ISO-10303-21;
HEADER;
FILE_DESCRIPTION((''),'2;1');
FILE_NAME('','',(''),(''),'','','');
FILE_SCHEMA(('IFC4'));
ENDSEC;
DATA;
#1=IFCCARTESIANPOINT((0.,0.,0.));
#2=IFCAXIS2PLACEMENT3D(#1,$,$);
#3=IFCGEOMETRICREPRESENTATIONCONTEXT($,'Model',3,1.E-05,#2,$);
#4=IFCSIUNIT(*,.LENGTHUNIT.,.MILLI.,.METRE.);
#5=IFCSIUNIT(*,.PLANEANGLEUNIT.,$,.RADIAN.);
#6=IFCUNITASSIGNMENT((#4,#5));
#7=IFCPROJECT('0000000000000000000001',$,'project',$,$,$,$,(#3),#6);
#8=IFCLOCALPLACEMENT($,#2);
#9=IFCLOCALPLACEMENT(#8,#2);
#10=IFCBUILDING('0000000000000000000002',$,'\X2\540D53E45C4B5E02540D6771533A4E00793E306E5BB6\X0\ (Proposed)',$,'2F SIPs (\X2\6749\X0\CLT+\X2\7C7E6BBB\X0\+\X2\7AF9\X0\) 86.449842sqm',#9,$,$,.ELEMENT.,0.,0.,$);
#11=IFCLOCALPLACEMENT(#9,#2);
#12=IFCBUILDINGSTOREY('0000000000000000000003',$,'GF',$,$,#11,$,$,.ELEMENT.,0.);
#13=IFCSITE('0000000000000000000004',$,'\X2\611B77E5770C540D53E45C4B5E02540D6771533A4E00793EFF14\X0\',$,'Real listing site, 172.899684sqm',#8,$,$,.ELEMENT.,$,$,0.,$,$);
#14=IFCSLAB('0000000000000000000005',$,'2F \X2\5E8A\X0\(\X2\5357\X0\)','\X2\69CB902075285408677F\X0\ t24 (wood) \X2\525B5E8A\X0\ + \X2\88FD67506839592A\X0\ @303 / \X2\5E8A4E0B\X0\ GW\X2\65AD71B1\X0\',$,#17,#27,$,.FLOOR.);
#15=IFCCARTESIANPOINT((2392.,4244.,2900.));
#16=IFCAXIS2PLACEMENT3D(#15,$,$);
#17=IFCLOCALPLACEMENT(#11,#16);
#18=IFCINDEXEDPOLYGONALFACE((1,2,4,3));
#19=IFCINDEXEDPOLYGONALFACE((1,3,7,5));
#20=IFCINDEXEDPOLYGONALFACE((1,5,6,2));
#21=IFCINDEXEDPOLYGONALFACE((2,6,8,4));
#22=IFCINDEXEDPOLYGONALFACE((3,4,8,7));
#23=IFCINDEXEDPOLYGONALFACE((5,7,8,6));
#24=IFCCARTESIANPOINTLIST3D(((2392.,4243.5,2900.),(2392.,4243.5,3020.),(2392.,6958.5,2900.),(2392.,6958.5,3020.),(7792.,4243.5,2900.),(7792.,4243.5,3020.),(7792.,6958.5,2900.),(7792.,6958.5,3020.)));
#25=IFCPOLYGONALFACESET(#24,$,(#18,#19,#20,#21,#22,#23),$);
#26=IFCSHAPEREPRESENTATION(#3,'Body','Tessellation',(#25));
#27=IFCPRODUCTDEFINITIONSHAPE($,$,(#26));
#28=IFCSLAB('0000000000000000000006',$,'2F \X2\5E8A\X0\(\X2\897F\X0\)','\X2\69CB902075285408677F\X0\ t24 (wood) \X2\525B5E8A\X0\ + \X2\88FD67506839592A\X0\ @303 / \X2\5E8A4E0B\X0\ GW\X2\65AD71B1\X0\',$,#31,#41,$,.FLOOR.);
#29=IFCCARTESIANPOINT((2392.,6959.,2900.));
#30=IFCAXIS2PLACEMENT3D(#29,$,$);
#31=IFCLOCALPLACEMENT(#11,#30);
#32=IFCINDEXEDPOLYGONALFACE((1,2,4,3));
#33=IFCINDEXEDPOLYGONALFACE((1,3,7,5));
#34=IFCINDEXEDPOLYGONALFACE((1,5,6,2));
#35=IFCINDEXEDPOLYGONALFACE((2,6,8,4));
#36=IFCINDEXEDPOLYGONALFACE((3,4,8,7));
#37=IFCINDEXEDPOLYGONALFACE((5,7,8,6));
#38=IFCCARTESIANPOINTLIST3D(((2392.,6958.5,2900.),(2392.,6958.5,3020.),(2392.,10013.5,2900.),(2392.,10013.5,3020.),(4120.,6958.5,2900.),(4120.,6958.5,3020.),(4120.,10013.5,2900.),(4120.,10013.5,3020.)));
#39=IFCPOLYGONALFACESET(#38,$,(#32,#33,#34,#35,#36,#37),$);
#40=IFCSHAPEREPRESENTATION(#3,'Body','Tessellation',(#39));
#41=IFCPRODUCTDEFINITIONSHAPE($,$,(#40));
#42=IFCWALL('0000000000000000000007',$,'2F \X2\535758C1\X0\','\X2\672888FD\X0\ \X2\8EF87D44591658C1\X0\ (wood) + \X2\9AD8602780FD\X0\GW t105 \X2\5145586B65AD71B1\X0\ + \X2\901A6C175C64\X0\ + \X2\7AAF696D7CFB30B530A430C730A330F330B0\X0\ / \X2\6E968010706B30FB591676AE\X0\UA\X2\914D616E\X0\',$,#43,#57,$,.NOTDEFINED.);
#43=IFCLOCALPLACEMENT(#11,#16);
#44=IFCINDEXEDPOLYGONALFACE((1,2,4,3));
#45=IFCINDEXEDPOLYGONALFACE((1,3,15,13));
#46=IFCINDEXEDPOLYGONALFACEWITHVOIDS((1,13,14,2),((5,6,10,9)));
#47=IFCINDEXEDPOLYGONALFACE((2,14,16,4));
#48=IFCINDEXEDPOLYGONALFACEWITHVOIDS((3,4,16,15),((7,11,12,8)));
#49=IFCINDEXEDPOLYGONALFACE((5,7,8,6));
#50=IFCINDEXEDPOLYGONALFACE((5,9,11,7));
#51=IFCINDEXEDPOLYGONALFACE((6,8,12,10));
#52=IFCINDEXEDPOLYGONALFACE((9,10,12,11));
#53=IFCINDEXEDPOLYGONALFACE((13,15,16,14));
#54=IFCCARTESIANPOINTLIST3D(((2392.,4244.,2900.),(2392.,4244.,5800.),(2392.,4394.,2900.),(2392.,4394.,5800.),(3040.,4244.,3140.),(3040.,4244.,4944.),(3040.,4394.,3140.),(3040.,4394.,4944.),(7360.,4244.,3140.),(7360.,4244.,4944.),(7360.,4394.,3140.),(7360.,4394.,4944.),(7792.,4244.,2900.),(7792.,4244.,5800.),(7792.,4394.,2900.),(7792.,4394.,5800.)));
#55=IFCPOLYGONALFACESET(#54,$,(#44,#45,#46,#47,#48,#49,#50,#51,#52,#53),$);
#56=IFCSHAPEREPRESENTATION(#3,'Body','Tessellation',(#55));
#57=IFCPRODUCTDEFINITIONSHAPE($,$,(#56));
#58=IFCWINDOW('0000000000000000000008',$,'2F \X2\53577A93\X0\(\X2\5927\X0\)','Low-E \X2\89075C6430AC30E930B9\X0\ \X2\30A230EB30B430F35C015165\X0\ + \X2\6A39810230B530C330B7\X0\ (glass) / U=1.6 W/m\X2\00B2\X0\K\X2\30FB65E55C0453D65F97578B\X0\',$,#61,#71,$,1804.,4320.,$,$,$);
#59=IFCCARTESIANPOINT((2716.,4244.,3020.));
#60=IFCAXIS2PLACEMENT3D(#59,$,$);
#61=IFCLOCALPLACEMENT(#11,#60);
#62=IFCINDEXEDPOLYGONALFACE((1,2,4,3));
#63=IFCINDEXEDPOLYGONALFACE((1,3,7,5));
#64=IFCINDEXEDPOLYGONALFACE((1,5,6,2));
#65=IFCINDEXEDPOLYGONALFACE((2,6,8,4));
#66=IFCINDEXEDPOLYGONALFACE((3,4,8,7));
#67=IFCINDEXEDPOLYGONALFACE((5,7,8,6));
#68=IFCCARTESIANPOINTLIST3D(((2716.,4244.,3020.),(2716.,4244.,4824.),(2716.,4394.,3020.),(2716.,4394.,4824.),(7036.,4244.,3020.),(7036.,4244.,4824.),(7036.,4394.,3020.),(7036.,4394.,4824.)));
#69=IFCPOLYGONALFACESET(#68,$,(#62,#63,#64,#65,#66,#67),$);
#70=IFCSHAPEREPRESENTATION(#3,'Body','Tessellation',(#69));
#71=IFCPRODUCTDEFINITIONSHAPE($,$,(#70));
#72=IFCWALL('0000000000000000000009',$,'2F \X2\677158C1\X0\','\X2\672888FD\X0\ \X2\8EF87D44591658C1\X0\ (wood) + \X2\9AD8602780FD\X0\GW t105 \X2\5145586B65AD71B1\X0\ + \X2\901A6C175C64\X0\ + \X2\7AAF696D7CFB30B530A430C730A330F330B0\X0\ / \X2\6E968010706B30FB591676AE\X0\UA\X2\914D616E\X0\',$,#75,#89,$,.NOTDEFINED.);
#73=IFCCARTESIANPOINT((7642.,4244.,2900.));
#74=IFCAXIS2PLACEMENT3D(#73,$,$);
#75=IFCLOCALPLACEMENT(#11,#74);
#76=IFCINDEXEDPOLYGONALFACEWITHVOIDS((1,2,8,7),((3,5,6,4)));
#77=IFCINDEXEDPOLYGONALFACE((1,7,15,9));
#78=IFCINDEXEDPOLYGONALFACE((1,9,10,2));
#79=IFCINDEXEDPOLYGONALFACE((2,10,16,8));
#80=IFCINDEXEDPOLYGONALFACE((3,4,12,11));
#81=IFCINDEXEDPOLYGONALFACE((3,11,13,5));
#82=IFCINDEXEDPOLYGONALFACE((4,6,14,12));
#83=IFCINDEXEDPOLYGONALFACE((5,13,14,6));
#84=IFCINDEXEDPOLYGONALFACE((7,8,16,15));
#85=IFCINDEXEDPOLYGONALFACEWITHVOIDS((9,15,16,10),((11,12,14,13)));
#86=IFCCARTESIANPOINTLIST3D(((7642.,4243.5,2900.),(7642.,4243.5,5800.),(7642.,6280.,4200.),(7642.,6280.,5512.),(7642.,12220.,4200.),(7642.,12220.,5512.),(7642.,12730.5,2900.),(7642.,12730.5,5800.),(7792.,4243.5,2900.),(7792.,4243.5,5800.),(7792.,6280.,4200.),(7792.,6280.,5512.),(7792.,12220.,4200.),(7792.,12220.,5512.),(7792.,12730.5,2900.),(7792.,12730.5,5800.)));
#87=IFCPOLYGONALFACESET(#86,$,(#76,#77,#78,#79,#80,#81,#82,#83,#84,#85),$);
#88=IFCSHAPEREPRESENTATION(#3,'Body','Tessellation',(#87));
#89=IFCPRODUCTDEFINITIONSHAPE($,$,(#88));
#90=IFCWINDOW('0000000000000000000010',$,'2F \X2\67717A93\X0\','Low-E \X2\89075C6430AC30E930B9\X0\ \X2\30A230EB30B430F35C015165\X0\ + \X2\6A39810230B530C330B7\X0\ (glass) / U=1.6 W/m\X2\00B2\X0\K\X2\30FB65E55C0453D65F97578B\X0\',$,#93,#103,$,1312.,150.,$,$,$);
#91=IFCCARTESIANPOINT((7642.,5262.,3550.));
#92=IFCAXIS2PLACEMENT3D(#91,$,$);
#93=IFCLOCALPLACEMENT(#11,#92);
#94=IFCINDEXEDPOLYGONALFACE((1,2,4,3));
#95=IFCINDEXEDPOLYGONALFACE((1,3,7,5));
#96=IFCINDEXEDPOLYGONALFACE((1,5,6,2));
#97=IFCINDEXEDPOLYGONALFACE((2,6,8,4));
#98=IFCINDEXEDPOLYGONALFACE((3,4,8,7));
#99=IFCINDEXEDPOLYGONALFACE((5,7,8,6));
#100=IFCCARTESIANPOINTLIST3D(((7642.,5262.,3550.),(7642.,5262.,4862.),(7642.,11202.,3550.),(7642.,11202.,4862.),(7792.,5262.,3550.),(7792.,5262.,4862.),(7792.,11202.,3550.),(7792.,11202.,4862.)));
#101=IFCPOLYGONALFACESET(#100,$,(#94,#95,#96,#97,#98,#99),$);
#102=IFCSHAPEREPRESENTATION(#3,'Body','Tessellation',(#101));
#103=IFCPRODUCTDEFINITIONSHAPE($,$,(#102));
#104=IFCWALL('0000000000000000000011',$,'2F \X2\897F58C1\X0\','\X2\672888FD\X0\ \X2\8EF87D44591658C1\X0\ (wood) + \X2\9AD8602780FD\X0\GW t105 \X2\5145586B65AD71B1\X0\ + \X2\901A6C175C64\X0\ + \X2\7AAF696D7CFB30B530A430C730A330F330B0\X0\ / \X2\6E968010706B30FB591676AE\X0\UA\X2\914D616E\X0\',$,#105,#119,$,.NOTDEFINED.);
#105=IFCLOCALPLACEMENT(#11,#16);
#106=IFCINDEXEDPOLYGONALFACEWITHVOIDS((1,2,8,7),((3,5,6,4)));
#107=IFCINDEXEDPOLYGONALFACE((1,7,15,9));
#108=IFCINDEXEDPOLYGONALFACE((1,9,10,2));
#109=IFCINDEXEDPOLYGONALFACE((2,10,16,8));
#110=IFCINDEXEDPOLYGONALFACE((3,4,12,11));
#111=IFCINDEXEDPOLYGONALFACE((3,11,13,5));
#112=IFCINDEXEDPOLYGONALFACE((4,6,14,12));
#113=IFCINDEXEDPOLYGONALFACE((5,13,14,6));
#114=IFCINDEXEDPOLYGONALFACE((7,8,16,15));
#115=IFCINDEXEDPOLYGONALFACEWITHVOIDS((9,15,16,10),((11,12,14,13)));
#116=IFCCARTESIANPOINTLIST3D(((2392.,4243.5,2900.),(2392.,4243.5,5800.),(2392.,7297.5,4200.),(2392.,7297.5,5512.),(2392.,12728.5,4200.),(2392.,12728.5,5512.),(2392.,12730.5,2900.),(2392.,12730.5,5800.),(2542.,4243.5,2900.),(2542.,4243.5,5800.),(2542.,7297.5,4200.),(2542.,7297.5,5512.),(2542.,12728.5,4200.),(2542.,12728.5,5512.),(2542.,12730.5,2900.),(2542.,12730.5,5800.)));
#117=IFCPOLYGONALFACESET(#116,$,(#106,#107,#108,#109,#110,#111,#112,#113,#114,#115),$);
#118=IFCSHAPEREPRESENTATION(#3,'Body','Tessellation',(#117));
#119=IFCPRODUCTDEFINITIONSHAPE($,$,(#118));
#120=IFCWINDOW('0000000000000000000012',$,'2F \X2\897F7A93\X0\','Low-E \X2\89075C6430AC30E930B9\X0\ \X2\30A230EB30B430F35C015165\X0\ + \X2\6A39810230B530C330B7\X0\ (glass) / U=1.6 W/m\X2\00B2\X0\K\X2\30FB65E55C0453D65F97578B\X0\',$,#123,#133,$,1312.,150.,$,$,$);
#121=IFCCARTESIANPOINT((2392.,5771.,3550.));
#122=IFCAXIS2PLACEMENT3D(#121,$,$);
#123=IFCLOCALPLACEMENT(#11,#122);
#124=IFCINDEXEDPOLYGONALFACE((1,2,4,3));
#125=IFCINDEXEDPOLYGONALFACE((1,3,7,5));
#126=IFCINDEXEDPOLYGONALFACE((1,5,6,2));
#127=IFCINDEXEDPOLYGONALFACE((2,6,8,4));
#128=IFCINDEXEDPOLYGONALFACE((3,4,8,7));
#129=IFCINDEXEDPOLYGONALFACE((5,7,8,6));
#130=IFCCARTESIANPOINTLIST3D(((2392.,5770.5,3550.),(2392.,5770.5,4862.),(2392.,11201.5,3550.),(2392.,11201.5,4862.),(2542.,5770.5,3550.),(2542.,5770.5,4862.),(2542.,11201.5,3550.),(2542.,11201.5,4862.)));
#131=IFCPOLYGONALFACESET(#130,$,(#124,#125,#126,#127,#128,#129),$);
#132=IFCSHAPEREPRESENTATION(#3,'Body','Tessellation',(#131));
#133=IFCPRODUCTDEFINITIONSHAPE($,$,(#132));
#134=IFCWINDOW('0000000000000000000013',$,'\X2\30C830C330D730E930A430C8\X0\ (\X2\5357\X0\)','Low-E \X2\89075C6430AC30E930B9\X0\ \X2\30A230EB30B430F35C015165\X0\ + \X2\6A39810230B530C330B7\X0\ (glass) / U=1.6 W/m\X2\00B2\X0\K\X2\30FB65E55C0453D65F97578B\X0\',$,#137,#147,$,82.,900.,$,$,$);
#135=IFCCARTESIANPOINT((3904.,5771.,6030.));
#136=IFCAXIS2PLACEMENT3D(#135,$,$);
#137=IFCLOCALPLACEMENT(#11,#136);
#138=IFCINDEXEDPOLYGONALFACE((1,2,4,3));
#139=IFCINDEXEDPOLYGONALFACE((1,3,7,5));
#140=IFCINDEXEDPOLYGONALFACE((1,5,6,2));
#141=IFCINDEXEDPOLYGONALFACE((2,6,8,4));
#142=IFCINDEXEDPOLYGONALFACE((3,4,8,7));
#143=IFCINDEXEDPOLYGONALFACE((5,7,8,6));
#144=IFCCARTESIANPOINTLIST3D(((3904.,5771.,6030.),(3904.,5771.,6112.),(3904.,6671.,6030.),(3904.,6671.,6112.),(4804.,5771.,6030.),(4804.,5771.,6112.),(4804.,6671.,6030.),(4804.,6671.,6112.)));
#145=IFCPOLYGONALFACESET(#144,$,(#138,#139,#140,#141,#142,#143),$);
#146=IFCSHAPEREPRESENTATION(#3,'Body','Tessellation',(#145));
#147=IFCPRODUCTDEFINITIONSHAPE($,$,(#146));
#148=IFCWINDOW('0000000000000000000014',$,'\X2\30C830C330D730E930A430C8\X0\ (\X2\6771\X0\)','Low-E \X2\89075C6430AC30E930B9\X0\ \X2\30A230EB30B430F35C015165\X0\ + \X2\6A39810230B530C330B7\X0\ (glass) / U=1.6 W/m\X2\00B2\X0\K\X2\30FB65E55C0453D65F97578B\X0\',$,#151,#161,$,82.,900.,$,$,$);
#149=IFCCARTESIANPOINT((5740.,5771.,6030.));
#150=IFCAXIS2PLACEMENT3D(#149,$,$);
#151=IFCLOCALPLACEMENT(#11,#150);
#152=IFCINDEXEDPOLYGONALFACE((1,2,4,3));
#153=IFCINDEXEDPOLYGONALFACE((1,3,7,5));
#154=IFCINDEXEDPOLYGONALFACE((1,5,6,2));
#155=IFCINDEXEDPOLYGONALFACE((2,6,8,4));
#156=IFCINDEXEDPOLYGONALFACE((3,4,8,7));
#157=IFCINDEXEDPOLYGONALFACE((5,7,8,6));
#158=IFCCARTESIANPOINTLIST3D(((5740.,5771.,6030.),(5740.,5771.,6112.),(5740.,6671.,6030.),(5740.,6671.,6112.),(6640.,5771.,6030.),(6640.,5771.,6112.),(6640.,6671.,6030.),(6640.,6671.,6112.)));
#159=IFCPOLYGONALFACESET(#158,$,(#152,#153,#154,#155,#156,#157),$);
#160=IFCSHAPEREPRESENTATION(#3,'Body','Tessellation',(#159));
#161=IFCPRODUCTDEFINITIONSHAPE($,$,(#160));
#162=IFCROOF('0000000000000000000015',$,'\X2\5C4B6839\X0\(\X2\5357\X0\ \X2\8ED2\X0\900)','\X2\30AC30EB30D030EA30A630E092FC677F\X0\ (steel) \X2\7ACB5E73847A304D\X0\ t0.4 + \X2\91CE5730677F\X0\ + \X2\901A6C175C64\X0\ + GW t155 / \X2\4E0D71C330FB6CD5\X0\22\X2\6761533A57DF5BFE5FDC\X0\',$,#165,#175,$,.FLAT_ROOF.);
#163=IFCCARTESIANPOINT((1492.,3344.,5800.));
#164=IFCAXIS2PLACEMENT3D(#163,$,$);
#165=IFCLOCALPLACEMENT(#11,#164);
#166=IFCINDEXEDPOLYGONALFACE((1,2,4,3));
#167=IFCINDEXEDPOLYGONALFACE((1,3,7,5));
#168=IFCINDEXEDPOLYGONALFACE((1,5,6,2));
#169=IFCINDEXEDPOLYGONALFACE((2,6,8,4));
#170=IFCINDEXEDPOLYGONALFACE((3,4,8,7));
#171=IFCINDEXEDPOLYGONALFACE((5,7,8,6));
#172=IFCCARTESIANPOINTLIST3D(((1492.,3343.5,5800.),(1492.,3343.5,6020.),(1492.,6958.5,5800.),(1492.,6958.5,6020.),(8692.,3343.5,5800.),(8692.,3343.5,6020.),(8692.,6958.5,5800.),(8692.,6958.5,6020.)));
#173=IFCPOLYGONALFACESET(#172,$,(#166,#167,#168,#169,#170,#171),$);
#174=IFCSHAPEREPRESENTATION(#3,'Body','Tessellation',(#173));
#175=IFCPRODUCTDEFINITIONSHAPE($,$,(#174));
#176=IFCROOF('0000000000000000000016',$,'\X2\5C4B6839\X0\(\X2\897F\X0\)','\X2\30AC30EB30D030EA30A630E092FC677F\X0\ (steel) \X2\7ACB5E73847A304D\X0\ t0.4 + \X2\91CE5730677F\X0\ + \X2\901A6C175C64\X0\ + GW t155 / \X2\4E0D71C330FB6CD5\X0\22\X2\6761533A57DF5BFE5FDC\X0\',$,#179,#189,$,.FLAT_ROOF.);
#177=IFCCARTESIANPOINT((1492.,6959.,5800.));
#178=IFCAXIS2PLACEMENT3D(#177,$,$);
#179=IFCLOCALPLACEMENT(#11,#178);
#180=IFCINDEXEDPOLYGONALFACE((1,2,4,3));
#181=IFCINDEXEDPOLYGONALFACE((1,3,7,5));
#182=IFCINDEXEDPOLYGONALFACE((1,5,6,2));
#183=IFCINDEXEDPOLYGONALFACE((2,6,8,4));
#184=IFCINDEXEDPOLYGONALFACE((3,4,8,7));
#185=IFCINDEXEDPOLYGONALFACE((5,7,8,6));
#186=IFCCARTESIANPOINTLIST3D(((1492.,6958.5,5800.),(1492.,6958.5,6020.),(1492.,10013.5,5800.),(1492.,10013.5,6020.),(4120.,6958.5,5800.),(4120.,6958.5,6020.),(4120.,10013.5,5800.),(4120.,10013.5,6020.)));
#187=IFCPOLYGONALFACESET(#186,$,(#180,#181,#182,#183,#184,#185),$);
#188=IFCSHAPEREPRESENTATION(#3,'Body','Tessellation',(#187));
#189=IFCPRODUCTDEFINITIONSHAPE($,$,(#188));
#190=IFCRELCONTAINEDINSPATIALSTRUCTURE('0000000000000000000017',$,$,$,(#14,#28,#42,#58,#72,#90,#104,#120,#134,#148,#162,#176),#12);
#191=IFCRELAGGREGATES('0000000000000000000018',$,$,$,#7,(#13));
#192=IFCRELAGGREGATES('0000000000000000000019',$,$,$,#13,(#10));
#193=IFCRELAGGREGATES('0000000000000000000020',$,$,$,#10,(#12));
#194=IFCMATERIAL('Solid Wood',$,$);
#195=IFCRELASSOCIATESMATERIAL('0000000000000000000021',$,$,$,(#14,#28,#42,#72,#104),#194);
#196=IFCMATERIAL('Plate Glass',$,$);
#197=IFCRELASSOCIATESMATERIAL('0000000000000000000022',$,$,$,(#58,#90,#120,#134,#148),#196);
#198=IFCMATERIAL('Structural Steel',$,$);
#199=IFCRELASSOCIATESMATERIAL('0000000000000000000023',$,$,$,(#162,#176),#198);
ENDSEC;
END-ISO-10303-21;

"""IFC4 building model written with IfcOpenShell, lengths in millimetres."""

from ifc_helpers import new_model, si_unit, frame, frame_2d, origin, place, context, project, spatial, rectangle, extrude, material, element, fill, save


model = new_model("IFC4")

# Units and contexts
model_context = context("Model", 3, precision=1e-05, world=origin())
ifc_project = project(units=[si_unit("LENGTHUNIT", "METRE", prefix="MILLI"), si_unit("PLANEANGLEUNIT", "RADIAN")], contexts=[model_context])

# Site, building, storey
site_placement = place(None, origin())
site = spatial("IfcSite", under=ifc_project, at=site_placement, Name="愛知県名古屋市名東区一社４", ObjectType="Real listing site, 172.899684sqm", CompositionType="ELEMENT", RefElevation=0.0)
building_placement = place(site_placement, origin())
building = spatial("IfcBuilding", under=site, at=building_placement, Name="名古屋市名東区一社の家 (Proposed)", ObjectType="2F SIPs (杉CLT+籾殻+竹) 86.449842sqm", CompositionType="ELEMENT", ElevationOfRefHeight=0.0, ElevationOfTerrain=0.0)
storey_placement = place(building_placement, origin())
storey = spatial("IfcBuildingStorey", under=building, at=storey_placement, Name="GF", CompositionType="ELEMENT", Elevation=0.0)

# Slabs
ifc_material_1 = material(Name="Solid Wood")
slab_1_placement = place(storey_placement, frame((2392.0, 4244.0, 2900.0)))
element("IfcSlab", 1, at=slab_1_placement, inside=storey, material=ifc_material_1, Name="2F 床(南)", Description="構造用合板 t24 (wood) 剛床 + 製材根太 @303 / 床下 GW断熱", PredefinedType="FLOOR", context=model_context, shape_type="SweptSolid", body=[
    extrude(rectangle(XDim=5400.0, YDim=2715.0, at=frame_2d((2700.0, 1357.0))), frame((2392.0, 4244.0, 2900.0)), (0.0, 0.0, 1.0), 120.0),
])
slab_2_placement = place(storey_placement, frame((2392.0, 6959.0, 2900.0)))
element("IfcSlab", 2, at=slab_2_placement, inside=storey, material=ifc_material_1, Name="2F 床(西)", Description="構造用合板 t24 (wood) 剛床 + 製材根太 @303 / 床下 GW断熱", PredefinedType="FLOOR", context=model_context, shape_type="SweptSolid", body=[
    extrude(rectangle(XDim=1728.0, YDim=3055.0, at=frame_2d((864.0, 1527.0))), frame((2392.0, 6959.0, 2900.0)), (0.0, 0.0, 1.0), 120.0),
])

# Walls, openings, windows
wall_1_placement = place(storey_placement, frame((2392.0, 4244.0, 2900.0)))
wall_1 = element("IfcWall", 3, at=wall_1_placement, inside=storey, material=ifc_material_1, Name="2F 南壁", Description="木製 軸組外壁 (wood) + 高性能GW t105 充填断熱 + 通気層 + 窯業系サイディング / 準耐火・外皮UA配慮", PredefinedType="NOTDEFINED", context=model_context, shape_type="SweptSolid", body=[
    extrude(rectangle(XDim=5400.0, YDim=150.0, at=frame_2d((2700.0, 75.0))), frame((2392.0, 4244.0, 2900.0)), (0.0, 0.0, 1.0), 2900.0),
])
opening_1_placement = place(storey_placement, frame((2716.0, 4244.0, 3020.0)))
opening_1 = element("IfcOpeningElement", 4, at=opening_1_placement, cuts=wall_1, PredefinedType="NOTDEFINED", context=model_context, shape_type="SweptSolid", body=[
    extrude(rectangle(XDim=4320.0, YDim=150.0, at=frame_2d((2160.0, 75.0))), frame((2716.0, 4244.0, 3020.0)), (0.0, 0.0, 1.0), 1804.0),
])
ifc_material_2 = material(Name="Plate Glass")
window_1_placement = place(storey_placement, frame((2716.0, 4244.0, 3020.0)))
window_1 = element("IfcWindow", 5, at=window_1_placement, inside=storey, material=ifc_material_2, Name="2F 南窓(大)", Description="Low-E 複層ガラス アルゴン封入 + 樹脂サッシ (glass) / U=1.6 W/m²K・日射取得型", OverallHeight=1804.0, OverallWidth=4320.0, context=model_context, shape_type="SweptSolid", body=[
    extrude(rectangle(XDim=4320.0, YDim=150.0, at=frame_2d((2160.0, 75.0))), frame((2716.0, 4244.0, 3020.0)), (0.0, 0.0, 1.0), 1804.0),
])
fill(opening_1, window_1)
wall_2_placement = place(storey_placement, frame((7642.0, 4244.0, 2900.0)))
wall_2 = element("IfcWall", 6, at=wall_2_placement, inside=storey, material=ifc_material_1, Name="2F 東壁", Description="木製 軸組外壁 (wood) + 高性能GW t105 充填断熱 + 通気層 + 窯業系サイディング / 準耐火・外皮UA配慮", PredefinedType="NOTDEFINED", context=model_context, shape_type="SweptSolid", body=[
    extrude(rectangle(XDim=150.0, YDim=8487.0, at=frame_2d((75.0, 4243.0))), frame((7642.0, 4244.0, 2900.0)), (0.0, 0.0, 1.0), 2900.0),
])
opening_2_placement = place(storey_placement, frame((7642.0, 5262.0, 3550.0)))
opening_2 = element("IfcOpeningElement", 7, at=opening_2_placement, cuts=wall_2, PredefinedType="NOTDEFINED", context=model_context, shape_type="SweptSolid", body=[
    extrude(rectangle(XDim=150.0, YDim=5940.0, at=frame_2d((75.0, 2970.0))), frame((7642.0, 5262.0, 3550.0)), (0.0, 0.0, 1.0), 1312.0),
])
window_2_placement = place(storey_placement, frame((7642.0, 5262.0, 3550.0)))
window_2 = element("IfcWindow", 8, at=window_2_placement, inside=storey, material=ifc_material_2, Name="2F 東窓", Description="Low-E 複層ガラス アルゴン封入 + 樹脂サッシ (glass) / U=1.6 W/m²K・日射取得型", OverallHeight=1312.0, OverallWidth=150.0, context=model_context, shape_type="SweptSolid", body=[
    extrude(rectangle(XDim=150.0, YDim=5940.0, at=frame_2d((75.0, 2970.0))), frame((7642.0, 5262.0, 3550.0)), (0.0, 0.0, 1.0), 1312.0),
])
fill(opening_2, window_2)
wall_3_placement = place(storey_placement, frame((2392.0, 4244.0, 2900.0)))
wall_3 = element("IfcWall", 9, at=wall_3_placement, inside=storey, material=ifc_material_1, Name="2F 西壁", Description="木製 軸組外壁 (wood) + 高性能GW t105 充填断熱 + 通気層 + 窯業系サイディング / 準耐火・外皮UA配慮", PredefinedType="NOTDEFINED", context=model_context, shape_type="SweptSolid", body=[
    extrude(rectangle(XDim=150.0, YDim=8487.0, at=frame_2d((75.0, 4243.0))), frame((2392.0, 4244.0, 2900.0)), (0.0, 0.0, 1.0), 2900.0),
])
opening_3_placement = place(storey_placement, frame((2392.0, 5771.0, 3550.0)))
opening_3 = element("IfcOpeningElement", 10, at=opening_3_placement, cuts=wall_3, PredefinedType="NOTDEFINED", context=model_context, shape_type="SweptSolid", body=[
    extrude(rectangle(XDim=150.0, YDim=5431.0, at=frame_2d((75.0, 2715.0))), frame((2392.0, 5771.0, 3550.0)), (0.0, 0.0, 1.0), 1312.0),
])
window_3_placement = place(storey_placement, frame((2392.0, 5771.0, 3550.0)))
window_3 = element("IfcWindow", 11, at=window_3_placement, inside=storey, material=ifc_material_2, Name="2F 西窓", Description="Low-E 複層ガラス アルゴン封入 + 樹脂サッシ (glass) / U=1.6 W/m²K・日射取得型", OverallHeight=1312.0, OverallWidth=150.0, context=model_context, shape_type="SweptSolid", body=[
    extrude(rectangle(XDim=150.0, YDim=5431.0, at=frame_2d((75.0, 2715.0))), frame((2392.0, 5771.0, 3550.0)), (0.0, 0.0, 1.0), 1312.0),
])
fill(opening_3, window_3)

# Windows
window_4_placement = place(storey_placement, frame((3904.0, 5771.0, 6030.0)))
element("IfcWindow", 12, at=window_4_placement, inside=storey, material=ifc_material_2, Name="トップライト (南)", Description="Low-E 複層ガラス アルゴン封入 + 樹脂サッシ (glass) / U=1.6 W/m²K・日射取得型", OverallHeight=82.0, OverallWidth=900.0, context=model_context, shape_type="SweptSolid", body=[
    extrude(rectangle(XDim=900.0, YDim=900.0, at=frame_2d((450.0, 450.0))), frame((3904.0, 5771.0, 6030.0)), (0.0, 0.0, 1.0), 82.0),
])
window_5_placement = place(storey_placement, frame((5740.0, 5771.0, 6030.0)))
element("IfcWindow", 13, at=window_5_placement, inside=storey, material=ifc_material_2, Name="トップライト (東)", Description="Low-E 複層ガラス アルゴン封入 + 樹脂サッシ (glass) / U=1.6 W/m²K・日射取得型", OverallHeight=82.0, OverallWidth=900.0, context=model_context, shape_type="SweptSolid", body=[
    extrude(rectangle(XDim=900.0, YDim=900.0, at=frame_2d((450.0, 450.0))), frame((5740.0, 5771.0, 6030.0)), (0.0, 0.0, 1.0), 82.0),
])

# Roofs
ifc_material_3 = material(Name="Structural Steel")
roof_1_placement = place(storey_placement, frame((1492.0, 3344.0, 5800.0)))
element("IfcRoof", 14, at=roof_1_placement, inside=storey, material=ifc_material_3, Name="屋根(南 軒900)", Description="ガルバリウム鋼板 (steel) 立平葺き t0.4 + 野地板 + 通気層 + GW t155 / 不燃・法22条区域対応", PredefinedType="FLAT_ROOF", context=model_context, shape_type="SweptSolid", body=[
    extrude(rectangle(XDim=7200.0, YDim=3615.0, at=frame_2d((3600.0, 1807.0))), frame((1492.0, 3344.0, 5800.0)), (0.0, 0.0, 1.0), 220.0),
])
roof_2_placement = place(storey_placement, frame((1492.0, 6959.0, 5800.0)))
element("IfcRoof", 15, at=roof_2_placement, inside=storey, material=ifc_material_3, Name="屋根(西)", Description="ガルバリウム鋼板 (steel) 立平葺き t0.4 + 野地板 + 通気層 + GW t155 / 不燃・法22条区域対応", PredefinedType="FLAT_ROOF", context=model_context, shape_type="SweptSolid", body=[
    extrude(rectangle(XDim=2628.0, YDim=3055.0, at=frame_2d((1314.0, 1527.0))), frame((1492.0, 6959.0, 5800.0)), (0.0, 0.0, 1.0), 220.0),
])

save(model, "model.ifc")
